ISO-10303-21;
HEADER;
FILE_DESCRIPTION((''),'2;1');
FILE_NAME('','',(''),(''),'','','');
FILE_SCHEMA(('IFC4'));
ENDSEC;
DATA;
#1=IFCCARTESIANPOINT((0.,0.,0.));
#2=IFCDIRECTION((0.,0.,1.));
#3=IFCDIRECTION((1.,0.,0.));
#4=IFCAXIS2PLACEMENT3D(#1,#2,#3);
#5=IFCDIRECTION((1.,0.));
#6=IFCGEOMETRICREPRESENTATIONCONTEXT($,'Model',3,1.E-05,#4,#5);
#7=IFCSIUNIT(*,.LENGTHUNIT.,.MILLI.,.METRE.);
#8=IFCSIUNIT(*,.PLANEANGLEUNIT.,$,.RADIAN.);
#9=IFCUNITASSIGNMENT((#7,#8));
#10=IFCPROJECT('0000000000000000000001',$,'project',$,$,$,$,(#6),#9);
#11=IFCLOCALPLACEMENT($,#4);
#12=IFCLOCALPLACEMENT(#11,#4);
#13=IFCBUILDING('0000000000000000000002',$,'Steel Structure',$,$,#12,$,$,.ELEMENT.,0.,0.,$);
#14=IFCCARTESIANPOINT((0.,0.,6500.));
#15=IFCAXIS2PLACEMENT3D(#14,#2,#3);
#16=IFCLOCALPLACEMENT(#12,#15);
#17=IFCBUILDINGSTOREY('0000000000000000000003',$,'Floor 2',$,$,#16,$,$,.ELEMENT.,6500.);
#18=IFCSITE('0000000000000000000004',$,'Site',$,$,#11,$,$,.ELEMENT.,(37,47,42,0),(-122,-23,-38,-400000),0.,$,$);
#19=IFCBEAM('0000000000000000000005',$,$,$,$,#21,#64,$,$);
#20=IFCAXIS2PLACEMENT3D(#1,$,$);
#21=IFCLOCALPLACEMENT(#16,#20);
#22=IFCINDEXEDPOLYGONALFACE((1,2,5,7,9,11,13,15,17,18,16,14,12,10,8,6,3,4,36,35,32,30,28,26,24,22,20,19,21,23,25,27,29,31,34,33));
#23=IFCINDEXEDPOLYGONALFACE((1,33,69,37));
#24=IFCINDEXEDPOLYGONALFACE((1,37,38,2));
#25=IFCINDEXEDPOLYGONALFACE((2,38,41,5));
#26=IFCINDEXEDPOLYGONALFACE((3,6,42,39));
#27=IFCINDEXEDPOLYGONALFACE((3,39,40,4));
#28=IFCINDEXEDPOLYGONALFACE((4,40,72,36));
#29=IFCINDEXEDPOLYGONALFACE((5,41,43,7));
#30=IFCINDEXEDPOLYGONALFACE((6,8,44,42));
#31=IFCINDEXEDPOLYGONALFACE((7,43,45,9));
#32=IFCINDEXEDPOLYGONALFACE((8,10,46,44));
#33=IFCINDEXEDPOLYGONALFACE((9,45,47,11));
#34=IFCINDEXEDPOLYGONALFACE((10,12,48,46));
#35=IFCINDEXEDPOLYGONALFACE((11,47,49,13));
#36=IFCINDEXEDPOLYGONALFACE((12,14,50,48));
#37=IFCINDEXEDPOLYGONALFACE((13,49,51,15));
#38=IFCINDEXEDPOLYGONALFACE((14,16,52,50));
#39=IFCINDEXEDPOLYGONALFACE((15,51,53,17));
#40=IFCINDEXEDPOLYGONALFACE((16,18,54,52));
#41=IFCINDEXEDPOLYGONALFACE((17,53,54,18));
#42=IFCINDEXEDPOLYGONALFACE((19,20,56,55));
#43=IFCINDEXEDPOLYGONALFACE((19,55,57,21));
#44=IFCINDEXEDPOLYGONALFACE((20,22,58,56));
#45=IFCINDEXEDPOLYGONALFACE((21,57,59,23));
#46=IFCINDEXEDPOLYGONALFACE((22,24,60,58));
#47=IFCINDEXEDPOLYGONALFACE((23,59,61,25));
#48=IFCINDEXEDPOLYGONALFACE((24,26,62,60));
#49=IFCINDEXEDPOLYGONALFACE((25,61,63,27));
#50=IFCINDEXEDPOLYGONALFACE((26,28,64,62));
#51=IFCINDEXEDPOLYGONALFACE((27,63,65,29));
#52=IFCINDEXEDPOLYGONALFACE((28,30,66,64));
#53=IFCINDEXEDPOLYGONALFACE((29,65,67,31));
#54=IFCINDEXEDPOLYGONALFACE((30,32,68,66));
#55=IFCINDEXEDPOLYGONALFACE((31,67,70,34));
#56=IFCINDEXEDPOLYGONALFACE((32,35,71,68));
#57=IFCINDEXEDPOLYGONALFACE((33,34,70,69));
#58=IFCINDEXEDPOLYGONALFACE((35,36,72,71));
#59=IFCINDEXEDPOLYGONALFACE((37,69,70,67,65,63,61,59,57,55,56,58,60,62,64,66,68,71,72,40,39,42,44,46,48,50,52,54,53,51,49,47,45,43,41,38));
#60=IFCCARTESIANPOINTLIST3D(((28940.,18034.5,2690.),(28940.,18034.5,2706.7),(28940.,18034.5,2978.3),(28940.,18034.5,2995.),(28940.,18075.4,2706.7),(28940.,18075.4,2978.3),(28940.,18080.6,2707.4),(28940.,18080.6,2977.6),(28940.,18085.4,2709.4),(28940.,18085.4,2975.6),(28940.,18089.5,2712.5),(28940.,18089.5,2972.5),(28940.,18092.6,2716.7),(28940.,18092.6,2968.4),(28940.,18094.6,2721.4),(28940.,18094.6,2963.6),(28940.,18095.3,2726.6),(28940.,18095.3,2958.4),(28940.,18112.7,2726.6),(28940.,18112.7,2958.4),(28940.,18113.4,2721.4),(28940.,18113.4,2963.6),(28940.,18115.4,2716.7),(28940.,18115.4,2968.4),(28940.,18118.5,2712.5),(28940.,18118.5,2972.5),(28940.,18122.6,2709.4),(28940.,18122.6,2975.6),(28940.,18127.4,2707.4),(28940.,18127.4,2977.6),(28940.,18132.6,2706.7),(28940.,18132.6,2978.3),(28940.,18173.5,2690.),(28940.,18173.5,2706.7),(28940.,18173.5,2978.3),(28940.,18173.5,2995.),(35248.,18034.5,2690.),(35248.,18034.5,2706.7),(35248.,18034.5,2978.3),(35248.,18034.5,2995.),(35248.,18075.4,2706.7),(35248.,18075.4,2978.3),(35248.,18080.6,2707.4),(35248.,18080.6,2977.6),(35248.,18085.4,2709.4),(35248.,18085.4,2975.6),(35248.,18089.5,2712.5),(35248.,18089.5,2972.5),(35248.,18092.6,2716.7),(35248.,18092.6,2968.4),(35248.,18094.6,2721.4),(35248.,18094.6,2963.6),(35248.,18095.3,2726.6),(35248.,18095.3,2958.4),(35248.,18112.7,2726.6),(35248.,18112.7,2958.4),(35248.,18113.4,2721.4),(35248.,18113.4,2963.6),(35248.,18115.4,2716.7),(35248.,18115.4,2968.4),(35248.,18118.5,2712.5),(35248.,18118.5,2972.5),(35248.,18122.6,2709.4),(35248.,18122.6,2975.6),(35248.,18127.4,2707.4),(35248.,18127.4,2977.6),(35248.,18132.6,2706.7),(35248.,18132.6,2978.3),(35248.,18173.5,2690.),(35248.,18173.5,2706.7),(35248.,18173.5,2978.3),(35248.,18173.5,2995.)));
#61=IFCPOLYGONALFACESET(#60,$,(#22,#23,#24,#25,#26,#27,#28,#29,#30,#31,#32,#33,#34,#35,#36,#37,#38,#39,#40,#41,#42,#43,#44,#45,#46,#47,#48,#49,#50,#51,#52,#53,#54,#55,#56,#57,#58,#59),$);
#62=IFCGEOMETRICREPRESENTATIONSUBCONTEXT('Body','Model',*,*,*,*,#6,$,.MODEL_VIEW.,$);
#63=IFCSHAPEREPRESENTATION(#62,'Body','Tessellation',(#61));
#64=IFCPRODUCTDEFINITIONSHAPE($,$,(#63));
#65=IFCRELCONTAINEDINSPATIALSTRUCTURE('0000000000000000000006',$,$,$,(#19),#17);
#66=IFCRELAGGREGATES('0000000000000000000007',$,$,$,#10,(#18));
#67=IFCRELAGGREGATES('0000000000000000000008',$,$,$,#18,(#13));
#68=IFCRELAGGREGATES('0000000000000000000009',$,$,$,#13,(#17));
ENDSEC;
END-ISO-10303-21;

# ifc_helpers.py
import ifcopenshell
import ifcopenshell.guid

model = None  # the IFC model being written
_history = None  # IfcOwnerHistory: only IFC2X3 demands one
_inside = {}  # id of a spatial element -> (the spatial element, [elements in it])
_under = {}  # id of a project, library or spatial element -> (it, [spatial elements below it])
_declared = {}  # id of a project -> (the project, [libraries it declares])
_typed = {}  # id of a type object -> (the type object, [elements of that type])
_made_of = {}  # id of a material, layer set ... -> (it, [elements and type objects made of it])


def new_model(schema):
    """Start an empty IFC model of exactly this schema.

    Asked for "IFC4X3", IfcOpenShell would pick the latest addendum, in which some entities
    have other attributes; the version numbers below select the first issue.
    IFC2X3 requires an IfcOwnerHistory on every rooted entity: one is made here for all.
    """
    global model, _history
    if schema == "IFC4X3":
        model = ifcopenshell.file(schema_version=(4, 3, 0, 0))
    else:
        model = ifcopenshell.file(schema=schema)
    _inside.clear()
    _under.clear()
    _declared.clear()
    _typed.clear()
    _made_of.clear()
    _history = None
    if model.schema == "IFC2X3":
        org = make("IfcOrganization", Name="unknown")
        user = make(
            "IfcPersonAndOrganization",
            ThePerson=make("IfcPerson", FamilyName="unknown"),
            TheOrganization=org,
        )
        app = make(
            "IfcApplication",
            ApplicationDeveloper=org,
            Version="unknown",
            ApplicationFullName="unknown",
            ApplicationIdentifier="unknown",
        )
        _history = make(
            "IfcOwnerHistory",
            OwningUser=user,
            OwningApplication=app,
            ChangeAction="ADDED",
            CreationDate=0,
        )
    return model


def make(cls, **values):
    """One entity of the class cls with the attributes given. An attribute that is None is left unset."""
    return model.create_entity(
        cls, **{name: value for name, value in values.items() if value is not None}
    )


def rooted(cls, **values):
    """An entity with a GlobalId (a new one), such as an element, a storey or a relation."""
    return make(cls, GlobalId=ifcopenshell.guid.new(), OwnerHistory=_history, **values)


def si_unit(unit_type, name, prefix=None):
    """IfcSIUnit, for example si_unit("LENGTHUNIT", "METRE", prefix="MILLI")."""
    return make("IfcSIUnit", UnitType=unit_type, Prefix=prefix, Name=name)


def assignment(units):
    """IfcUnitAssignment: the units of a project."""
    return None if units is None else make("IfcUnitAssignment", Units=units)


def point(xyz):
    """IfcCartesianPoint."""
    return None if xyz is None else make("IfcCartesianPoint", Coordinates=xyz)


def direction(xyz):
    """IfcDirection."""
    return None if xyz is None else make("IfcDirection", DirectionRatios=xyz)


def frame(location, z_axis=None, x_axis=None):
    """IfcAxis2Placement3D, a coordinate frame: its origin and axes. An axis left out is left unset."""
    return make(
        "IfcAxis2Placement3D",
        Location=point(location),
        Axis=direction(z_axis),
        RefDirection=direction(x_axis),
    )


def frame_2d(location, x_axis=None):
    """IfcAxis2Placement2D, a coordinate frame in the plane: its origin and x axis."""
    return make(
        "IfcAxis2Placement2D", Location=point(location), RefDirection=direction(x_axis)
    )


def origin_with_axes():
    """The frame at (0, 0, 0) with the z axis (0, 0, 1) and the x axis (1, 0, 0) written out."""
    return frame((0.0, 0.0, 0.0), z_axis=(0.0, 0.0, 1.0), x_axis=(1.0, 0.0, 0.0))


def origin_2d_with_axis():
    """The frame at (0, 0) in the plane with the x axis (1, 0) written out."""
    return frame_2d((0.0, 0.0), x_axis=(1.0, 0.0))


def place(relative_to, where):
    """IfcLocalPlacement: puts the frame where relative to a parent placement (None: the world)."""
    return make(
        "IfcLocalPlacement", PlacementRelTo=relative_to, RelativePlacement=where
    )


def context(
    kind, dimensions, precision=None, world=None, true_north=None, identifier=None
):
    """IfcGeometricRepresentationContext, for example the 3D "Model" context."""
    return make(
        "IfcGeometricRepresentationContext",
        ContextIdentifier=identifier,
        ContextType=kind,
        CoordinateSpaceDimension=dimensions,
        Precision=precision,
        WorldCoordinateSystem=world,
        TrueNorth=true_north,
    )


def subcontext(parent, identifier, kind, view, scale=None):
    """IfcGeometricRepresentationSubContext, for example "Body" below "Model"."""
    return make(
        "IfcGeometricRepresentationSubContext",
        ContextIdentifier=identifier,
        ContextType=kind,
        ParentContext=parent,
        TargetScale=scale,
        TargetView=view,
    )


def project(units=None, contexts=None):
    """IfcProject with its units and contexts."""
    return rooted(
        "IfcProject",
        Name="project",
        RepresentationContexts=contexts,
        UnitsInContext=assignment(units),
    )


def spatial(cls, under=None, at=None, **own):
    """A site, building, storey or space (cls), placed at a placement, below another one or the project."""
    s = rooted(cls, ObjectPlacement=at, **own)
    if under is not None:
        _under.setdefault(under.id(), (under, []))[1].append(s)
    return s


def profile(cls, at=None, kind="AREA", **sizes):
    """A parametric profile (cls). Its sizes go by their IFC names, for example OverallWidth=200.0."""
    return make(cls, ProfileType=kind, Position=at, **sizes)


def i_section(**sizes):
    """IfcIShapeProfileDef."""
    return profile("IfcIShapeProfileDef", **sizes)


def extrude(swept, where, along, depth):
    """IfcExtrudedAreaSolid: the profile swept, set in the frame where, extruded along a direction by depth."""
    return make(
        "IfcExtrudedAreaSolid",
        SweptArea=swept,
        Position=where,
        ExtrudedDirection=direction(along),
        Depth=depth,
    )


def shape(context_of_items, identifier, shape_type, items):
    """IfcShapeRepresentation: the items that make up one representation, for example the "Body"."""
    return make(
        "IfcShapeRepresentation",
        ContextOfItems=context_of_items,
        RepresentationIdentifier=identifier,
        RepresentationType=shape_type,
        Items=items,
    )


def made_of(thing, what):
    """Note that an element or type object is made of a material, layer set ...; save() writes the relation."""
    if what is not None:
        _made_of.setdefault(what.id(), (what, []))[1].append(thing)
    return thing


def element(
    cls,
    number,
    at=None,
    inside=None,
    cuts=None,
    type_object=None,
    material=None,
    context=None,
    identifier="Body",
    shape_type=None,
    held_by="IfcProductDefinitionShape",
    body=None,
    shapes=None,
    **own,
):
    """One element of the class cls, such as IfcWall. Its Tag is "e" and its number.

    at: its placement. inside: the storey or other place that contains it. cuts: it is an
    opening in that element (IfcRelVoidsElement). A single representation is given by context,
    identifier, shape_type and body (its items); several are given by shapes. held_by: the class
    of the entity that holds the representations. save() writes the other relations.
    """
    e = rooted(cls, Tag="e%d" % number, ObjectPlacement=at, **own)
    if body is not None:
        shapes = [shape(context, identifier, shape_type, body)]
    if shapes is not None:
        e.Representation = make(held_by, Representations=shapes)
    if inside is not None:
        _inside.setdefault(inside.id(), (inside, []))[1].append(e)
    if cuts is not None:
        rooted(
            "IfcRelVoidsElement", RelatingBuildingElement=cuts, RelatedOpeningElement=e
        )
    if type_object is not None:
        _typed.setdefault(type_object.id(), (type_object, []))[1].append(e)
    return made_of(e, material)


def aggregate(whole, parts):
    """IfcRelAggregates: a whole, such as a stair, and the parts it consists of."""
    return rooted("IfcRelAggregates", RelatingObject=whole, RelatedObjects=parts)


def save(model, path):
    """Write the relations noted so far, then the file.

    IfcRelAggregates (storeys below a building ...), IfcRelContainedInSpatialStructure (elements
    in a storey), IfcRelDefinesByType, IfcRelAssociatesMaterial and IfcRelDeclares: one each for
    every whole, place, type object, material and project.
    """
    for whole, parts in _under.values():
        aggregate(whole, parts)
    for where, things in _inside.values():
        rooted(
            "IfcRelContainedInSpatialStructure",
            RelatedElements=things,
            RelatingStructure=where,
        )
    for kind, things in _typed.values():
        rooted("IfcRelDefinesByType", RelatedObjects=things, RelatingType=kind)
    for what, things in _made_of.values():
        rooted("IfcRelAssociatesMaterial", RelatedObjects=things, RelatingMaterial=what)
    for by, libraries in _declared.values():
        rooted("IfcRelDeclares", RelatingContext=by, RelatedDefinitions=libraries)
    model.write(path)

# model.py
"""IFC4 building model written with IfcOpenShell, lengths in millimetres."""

from ifc_helpers import new_model, si_unit, direction, frame, origin_with_axes, origin_2d_with_axis, place, context, subcontext, project, spatial, i_section, extrude, element, save


model = new_model("IFC4")

# Units and contexts
model_context = context("Model", 3, precision=1e-05, world=origin_with_axes(), true_north=direction((1.0, 0.0)))
body_context = subcontext(model_context, "Body", "Model", "MODEL_VIEW")
ifc_project = project(units=[si_unit("LENGTHUNIT", "METRE", prefix="MILLI"), si_unit("PLANEANGLEUNIT", "RADIAN")], contexts=[model_context])

# Site, building, storey
site_placement = place(None, origin_with_axes())
site = spatial("IfcSite", under=ifc_project, at=site_placement, Name="Site", CompositionType="ELEMENT", RefLatitude=(37, 47, 42, 0), RefLongitude=(-122, -23, -38, -400000), RefElevation=0.0)
building_placement = place(site_placement, origin_with_axes())
building = spatial("IfcBuilding", under=site, at=building_placement, Name="Steel Structure", CompositionType="ELEMENT", ElevationOfRefHeight=0.0, ElevationOfTerrain=0.0)
storey_placement = place(building_placement, frame((0.0, 0.0, 6500.0), z_axis=(0.0, 0.0, 1.0), x_axis=(1.0, 0.0, 0.0)))
storey = spatial("IfcBuildingStorey", under=building, at=storey_placement, Name="Floor 2", CompositionType="ELEMENT", Elevation=6500.0)

# Beam
for number, where, z_axis, x_axis in (
    (1, (35248.0, 18104.0, 2690.0), (-1.0, 0.0, 0.0), (0.0, -1.0, 0.0)),
):
    element("IfcBeam", number, at=place(storey_placement, frame(where, z_axis=z_axis, x_axis=x_axis)), inside=storey, context=body_context, shape_type="SweptSolid", body=[
        extrude(i_section(OverallWidth=139.0, OverallDepth=305.0, WebThickness=17.4, FlangeThickness=16.7, FilletRadius=19.9, at=origin_2d_with_axis()), frame((0.0, 152.5, 0.0), z_axis=(0.0, 0.0, 1.0), x_axis=(1.0, 0.0, 0.0)), (0.0, 0.0, 1.0), 6308.0),
    ])

save(model, "model.ifc")
